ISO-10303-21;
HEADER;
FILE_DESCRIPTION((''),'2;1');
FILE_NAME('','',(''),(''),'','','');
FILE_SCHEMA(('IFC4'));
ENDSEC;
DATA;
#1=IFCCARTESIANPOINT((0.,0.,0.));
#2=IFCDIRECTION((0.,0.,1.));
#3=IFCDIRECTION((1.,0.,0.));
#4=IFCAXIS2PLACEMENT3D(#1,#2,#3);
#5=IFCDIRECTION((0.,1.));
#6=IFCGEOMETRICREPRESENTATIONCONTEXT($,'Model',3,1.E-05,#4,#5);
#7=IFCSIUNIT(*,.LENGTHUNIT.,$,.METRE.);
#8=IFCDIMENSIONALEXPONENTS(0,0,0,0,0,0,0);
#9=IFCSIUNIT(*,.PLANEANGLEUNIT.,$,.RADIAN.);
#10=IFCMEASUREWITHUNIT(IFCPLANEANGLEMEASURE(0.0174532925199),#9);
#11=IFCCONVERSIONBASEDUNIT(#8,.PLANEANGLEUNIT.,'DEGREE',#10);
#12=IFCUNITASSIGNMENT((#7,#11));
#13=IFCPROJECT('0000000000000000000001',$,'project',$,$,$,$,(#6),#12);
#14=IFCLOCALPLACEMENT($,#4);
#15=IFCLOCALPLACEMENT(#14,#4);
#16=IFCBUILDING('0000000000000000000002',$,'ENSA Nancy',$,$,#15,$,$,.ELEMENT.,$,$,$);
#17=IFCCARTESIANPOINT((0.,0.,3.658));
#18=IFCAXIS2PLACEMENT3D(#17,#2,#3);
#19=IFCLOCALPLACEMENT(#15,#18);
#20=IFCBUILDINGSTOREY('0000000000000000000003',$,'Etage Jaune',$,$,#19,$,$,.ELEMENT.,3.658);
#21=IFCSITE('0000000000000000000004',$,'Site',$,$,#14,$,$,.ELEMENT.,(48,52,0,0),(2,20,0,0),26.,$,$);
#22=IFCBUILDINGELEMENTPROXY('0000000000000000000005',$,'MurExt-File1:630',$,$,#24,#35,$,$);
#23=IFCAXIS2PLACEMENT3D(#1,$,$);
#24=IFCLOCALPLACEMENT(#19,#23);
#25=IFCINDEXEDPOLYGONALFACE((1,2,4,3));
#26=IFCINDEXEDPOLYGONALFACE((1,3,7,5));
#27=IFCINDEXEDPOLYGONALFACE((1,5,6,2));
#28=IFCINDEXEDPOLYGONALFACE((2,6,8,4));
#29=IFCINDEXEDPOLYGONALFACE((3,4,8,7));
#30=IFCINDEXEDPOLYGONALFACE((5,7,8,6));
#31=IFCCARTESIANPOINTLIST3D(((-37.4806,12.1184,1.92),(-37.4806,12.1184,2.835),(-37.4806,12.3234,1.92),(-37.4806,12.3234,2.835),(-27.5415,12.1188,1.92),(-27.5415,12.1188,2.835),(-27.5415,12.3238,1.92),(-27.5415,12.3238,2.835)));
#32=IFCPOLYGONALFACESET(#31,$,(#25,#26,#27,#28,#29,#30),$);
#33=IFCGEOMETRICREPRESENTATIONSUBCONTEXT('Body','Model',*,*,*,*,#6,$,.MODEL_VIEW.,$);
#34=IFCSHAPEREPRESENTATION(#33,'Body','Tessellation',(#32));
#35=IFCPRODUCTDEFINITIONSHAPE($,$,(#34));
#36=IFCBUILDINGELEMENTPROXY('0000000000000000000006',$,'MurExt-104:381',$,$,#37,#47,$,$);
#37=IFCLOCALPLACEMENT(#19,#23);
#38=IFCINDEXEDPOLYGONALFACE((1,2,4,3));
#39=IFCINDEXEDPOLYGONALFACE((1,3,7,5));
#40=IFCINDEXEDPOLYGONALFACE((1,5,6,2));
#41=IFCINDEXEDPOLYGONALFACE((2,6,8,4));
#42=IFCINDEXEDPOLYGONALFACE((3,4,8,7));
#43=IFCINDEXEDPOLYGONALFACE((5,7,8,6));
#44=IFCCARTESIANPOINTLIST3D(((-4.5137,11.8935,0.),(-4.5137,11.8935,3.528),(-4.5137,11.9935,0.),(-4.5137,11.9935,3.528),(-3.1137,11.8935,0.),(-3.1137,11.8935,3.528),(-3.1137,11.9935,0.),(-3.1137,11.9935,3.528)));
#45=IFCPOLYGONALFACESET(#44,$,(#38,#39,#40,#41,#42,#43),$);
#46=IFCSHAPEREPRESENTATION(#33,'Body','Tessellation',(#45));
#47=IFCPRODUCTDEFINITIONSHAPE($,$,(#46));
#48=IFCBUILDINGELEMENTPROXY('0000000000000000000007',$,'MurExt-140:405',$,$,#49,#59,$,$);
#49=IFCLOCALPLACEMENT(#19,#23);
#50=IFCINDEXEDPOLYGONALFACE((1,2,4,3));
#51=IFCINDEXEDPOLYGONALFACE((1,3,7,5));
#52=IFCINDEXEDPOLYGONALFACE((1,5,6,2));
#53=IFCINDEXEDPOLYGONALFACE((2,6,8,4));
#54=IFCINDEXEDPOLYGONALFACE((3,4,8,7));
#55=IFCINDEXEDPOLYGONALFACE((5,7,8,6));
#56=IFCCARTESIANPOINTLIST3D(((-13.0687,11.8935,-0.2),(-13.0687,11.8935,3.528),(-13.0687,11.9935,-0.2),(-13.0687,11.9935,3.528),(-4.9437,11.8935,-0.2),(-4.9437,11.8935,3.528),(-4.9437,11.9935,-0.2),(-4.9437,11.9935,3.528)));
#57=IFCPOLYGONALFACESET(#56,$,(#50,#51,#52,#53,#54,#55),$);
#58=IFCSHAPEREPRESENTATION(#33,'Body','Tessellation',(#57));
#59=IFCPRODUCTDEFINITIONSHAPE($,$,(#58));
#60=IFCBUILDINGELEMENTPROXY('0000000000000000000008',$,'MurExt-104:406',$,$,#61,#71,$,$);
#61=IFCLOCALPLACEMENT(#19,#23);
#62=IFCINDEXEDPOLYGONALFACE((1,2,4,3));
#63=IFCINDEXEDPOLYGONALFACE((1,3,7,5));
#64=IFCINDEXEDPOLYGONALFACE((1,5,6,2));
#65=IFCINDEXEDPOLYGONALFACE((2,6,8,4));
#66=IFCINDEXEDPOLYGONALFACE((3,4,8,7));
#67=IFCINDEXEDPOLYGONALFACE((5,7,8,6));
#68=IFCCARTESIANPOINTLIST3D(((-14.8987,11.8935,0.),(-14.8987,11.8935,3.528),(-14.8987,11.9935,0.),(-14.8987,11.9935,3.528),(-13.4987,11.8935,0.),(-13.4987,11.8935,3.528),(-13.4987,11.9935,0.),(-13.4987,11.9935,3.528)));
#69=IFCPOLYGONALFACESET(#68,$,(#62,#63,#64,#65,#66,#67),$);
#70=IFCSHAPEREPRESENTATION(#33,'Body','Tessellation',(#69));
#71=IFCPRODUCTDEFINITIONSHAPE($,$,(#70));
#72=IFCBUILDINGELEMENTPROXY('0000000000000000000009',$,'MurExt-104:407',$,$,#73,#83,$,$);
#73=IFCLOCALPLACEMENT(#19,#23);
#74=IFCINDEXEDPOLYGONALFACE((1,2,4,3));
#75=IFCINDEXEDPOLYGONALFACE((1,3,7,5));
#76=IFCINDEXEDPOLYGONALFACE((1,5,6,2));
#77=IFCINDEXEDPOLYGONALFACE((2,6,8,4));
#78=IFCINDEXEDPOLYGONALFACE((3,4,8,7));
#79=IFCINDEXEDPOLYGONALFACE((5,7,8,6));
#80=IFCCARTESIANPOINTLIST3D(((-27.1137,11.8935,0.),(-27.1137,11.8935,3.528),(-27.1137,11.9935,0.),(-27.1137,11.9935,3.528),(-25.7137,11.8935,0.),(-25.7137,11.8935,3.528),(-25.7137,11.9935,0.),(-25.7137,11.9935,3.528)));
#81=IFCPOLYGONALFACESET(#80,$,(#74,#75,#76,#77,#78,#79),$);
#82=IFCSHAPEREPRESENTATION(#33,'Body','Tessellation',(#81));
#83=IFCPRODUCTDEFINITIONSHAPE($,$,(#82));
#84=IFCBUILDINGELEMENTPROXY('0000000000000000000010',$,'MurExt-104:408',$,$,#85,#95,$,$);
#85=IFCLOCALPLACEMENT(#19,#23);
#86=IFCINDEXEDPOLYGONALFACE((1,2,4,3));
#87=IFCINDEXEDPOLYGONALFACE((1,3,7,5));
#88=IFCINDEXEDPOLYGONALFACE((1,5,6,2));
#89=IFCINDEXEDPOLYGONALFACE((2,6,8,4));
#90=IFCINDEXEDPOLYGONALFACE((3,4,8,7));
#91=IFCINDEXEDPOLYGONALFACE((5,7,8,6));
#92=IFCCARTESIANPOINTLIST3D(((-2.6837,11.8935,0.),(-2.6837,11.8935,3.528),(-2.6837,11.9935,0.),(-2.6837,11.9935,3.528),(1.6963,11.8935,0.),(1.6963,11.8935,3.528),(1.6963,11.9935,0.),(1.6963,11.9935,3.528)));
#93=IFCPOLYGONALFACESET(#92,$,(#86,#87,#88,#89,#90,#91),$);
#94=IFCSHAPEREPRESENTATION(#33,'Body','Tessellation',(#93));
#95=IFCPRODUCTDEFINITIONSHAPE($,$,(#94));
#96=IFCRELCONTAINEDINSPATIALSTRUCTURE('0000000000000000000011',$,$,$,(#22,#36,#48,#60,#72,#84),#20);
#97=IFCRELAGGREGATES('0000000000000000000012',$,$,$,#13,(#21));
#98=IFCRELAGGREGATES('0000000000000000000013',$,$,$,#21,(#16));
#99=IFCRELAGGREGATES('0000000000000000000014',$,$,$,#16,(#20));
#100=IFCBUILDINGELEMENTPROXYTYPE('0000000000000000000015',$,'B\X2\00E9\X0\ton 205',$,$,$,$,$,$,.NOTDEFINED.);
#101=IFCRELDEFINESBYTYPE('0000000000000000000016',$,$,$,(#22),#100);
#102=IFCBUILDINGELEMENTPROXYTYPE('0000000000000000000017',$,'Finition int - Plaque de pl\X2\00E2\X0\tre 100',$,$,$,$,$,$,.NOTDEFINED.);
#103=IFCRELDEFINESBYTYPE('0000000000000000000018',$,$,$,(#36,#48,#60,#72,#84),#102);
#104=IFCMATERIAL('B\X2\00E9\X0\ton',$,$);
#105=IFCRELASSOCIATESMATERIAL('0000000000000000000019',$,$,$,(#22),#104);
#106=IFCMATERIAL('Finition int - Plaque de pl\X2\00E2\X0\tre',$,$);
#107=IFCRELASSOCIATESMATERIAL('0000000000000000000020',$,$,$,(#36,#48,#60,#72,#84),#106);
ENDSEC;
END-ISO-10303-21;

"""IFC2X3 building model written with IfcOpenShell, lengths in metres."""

from ifc_helpers import new_model, entity, si_unit, converted_unit, direction, frame, origin_with_axes, place, context, subcontext, project, spatial, polyline, outline, extrude, material, type_object, element, save


model = new_model("IFC2X3")

# Units and contexts
model_context = context("Model", 3, precision=1e-05, world=origin_with_axes(), true_north=direction((0.0, 1.0)))
body_context = subcontext(model_context, "Body", "Model", "MODEL_VIEW")
ifc_project = project(units=[si_unit("LENGTHUNIT", "METRE"), converted_unit("PLANEANGLEUNIT", "DEGREE", entity("IfcPlaneAngleMeasure", 0.0174532925199), si_unit("PLANEANGLEUNIT", "RADIAN"), dimensions=[0, 0, 0, 0, 0, 0, 0])], contexts=[model_context])

# Site, building, storey
site_placement = place(None, origin_with_axes())
site = spatial("IfcSite", under=ifc_project, at=site_placement, Name="Site", CompositionType="ELEMENT", RefLatitude=(48, 52, 0, 0), RefLongitude=(2, 20, 0, 0), RefElevation=26.0)
building_placement = place(site_placement, origin_with_axes())
building = spatial("IfcBuilding", under=site, at=building_placement, Name="ENSA Nancy", CompositionType="ELEMENT")
storey_placement = place(building_placement, frame((0.0, 0.0, 3.658), z_axis=(0.0, 0.0, 1.0), x_axis=(1.0, 0.0, 0.0)))
storey = spatial("IfcBuildingStorey", under=building, at=storey_placement, Name="Etage Jaune", CompositionType="ELEMENT", Elevation=3.658)

# Shared definitions
ifc_material_1 = material(Name="Finition int - Plaque de plâtre")

# Shared definitions
ifc_material_2 = material(Name="Béton")

# Building element proxies
building_element_proxy_type_1 = type_object("IfcBuildingElementProxyType", Name="Béton 205", PredefinedType="NOTDEFINED")
for number, where, z_axis, x_axis, name in (
    (1, (-37.4806, 12.3234, 1.92), (0.0, 0.0, 1.0), (1.0, 0.000034, 0.0), "MurExt-File1:630"),
):
    element("IfcBuildingElementProxy", number, at=place(storey_placement, frame(where, z_axis=z_axis, x_axis=x_axis)), inside=storey, type_object=building_element_proxy_type_1, material=ifc_material_2, Name=name, context=body_context, shape_type="SweptSolid", body=[
        extrude(outline(polyline([(0.0, -0.205), (9.9392, -0.205), (9.9392, 0.0), (0.0, 0.0), (0.0, -0.205)])), origin_with_axes(), (0.0, 0.0, 1.0), 0.915),
    ])
building_element_proxy_type_2 = type_object("IfcBuildingElementProxyType", Name="Finition int - Plaque de plâtre 100", PredefinedType="NOTDEFINED")
proxy_1_placement = place(storey_placement, frame((-4.5137, 11.8935, 0.0), z_axis=(0.0, 0.0, 1.0), x_axis=(1.0, 0.000001, 0.0)))
element("IfcBuildingElementProxy", 2, at=proxy_1_placement, inside=storey, type_object=building_element_proxy_type_2, material=ifc_material_1, Name="MurExt-104:381", context=body_context, shape_type="SweptSolid", body=[
    extrude(outline(polyline([(0.0, 0.0), (1.4, 0.0), (1.4, 0.1), (0.0, 0.1), (0.0, 0.0)])), origin_with_axes(), (0.0, 0.0, 1.0), 3.528),
])
proxy_2_placement = place(storey_placement, frame((-13.0687, 11.8935, -0.2), z_axis=(0.0, 0.0, 1.0), x_axis=(1.0, 0.0, 0.0)))
element("IfcBuildingElementProxy", 3, at=proxy_2_placement, inside=storey, type_object=building_element_proxy_type_2, material=ifc_material_1, Name="MurExt-140:405", context=body_context, shape_type="SweptSolid", body=[
    extrude(outline(polyline([(0.0, 0.0), (8.125, 0.0), (8.125, 0.1), (0.0, 0.1), (0.0, 0.0)])), origin_with_axes(), (0.0, 0.0, 1.0), 3.728),
])
proxy_3_placement = place(storey_placement, frame((-14.8987, 11.8935, 0.0), z_axis=(0.0, 0.0, 1.0), x_axis=(1.0, 0.0, 0.0)))
element("IfcBuildingElementProxy", 4, at=proxy_3_placement, inside=storey, type_object=building_element_proxy_type_2, material=ifc_material_1, Name="MurExt-104:406", context=body_context, shape_type="SweptSolid", body=[
    extrude(outline(polyline([(0.0, 0.0), (1.4, 0.0), (1.4, 0.1), (0.0, 0.1), (0.0, 0.0)])), origin_with_axes(), (0.0, 0.0, 1.0), 3.528),
])
proxy_4_placement = place(storey_placement, frame((-27.1137, 11.8935, 0.0), z_axis=(0.0, 0.0, 1.0), x_axis=(1.0, 0.0, 0.0)))
element("IfcBuildingElementProxy", 5, at=proxy_4_placement, inside=storey, type_object=building_element_proxy_type_2, material=ifc_material_1, Name="MurExt-104:407", context=body_context, shape_type="SweptSolid", body=[
    extrude(outline(polyline([(0.0, 0.0), (1.4, 0.0), (1.4, 0.1), (0.0, 0.1), (0.0, 0.0)])), origin_with_axes(), (0.0, 0.0, 1.0), 3.528),
])
proxy_5_placement = place(storey_placement, frame((-2.6837, 11.8935, 0.0), z_axis=(0.0, 0.0, 1.0), x_axis=(1.0, 0.0, 0.0)))
element("IfcBuildingElementProxy", 6, at=proxy_5_placement, inside=storey, type_object=building_element_proxy_type_2, material=ifc_material_1, Name="MurExt-104:408", context=body_context, shape_type="SweptSolid", body=[
    extrude(outline(polyline([(0.0, 0.0), (4.38, 0.0), (4.38, 0.1), (0.0, 0.1), (0.0, 0.0)])), origin_with_axes(), (0.0, 0.0, 1.0), 3.528),
])

save(model, "model.ifc")
